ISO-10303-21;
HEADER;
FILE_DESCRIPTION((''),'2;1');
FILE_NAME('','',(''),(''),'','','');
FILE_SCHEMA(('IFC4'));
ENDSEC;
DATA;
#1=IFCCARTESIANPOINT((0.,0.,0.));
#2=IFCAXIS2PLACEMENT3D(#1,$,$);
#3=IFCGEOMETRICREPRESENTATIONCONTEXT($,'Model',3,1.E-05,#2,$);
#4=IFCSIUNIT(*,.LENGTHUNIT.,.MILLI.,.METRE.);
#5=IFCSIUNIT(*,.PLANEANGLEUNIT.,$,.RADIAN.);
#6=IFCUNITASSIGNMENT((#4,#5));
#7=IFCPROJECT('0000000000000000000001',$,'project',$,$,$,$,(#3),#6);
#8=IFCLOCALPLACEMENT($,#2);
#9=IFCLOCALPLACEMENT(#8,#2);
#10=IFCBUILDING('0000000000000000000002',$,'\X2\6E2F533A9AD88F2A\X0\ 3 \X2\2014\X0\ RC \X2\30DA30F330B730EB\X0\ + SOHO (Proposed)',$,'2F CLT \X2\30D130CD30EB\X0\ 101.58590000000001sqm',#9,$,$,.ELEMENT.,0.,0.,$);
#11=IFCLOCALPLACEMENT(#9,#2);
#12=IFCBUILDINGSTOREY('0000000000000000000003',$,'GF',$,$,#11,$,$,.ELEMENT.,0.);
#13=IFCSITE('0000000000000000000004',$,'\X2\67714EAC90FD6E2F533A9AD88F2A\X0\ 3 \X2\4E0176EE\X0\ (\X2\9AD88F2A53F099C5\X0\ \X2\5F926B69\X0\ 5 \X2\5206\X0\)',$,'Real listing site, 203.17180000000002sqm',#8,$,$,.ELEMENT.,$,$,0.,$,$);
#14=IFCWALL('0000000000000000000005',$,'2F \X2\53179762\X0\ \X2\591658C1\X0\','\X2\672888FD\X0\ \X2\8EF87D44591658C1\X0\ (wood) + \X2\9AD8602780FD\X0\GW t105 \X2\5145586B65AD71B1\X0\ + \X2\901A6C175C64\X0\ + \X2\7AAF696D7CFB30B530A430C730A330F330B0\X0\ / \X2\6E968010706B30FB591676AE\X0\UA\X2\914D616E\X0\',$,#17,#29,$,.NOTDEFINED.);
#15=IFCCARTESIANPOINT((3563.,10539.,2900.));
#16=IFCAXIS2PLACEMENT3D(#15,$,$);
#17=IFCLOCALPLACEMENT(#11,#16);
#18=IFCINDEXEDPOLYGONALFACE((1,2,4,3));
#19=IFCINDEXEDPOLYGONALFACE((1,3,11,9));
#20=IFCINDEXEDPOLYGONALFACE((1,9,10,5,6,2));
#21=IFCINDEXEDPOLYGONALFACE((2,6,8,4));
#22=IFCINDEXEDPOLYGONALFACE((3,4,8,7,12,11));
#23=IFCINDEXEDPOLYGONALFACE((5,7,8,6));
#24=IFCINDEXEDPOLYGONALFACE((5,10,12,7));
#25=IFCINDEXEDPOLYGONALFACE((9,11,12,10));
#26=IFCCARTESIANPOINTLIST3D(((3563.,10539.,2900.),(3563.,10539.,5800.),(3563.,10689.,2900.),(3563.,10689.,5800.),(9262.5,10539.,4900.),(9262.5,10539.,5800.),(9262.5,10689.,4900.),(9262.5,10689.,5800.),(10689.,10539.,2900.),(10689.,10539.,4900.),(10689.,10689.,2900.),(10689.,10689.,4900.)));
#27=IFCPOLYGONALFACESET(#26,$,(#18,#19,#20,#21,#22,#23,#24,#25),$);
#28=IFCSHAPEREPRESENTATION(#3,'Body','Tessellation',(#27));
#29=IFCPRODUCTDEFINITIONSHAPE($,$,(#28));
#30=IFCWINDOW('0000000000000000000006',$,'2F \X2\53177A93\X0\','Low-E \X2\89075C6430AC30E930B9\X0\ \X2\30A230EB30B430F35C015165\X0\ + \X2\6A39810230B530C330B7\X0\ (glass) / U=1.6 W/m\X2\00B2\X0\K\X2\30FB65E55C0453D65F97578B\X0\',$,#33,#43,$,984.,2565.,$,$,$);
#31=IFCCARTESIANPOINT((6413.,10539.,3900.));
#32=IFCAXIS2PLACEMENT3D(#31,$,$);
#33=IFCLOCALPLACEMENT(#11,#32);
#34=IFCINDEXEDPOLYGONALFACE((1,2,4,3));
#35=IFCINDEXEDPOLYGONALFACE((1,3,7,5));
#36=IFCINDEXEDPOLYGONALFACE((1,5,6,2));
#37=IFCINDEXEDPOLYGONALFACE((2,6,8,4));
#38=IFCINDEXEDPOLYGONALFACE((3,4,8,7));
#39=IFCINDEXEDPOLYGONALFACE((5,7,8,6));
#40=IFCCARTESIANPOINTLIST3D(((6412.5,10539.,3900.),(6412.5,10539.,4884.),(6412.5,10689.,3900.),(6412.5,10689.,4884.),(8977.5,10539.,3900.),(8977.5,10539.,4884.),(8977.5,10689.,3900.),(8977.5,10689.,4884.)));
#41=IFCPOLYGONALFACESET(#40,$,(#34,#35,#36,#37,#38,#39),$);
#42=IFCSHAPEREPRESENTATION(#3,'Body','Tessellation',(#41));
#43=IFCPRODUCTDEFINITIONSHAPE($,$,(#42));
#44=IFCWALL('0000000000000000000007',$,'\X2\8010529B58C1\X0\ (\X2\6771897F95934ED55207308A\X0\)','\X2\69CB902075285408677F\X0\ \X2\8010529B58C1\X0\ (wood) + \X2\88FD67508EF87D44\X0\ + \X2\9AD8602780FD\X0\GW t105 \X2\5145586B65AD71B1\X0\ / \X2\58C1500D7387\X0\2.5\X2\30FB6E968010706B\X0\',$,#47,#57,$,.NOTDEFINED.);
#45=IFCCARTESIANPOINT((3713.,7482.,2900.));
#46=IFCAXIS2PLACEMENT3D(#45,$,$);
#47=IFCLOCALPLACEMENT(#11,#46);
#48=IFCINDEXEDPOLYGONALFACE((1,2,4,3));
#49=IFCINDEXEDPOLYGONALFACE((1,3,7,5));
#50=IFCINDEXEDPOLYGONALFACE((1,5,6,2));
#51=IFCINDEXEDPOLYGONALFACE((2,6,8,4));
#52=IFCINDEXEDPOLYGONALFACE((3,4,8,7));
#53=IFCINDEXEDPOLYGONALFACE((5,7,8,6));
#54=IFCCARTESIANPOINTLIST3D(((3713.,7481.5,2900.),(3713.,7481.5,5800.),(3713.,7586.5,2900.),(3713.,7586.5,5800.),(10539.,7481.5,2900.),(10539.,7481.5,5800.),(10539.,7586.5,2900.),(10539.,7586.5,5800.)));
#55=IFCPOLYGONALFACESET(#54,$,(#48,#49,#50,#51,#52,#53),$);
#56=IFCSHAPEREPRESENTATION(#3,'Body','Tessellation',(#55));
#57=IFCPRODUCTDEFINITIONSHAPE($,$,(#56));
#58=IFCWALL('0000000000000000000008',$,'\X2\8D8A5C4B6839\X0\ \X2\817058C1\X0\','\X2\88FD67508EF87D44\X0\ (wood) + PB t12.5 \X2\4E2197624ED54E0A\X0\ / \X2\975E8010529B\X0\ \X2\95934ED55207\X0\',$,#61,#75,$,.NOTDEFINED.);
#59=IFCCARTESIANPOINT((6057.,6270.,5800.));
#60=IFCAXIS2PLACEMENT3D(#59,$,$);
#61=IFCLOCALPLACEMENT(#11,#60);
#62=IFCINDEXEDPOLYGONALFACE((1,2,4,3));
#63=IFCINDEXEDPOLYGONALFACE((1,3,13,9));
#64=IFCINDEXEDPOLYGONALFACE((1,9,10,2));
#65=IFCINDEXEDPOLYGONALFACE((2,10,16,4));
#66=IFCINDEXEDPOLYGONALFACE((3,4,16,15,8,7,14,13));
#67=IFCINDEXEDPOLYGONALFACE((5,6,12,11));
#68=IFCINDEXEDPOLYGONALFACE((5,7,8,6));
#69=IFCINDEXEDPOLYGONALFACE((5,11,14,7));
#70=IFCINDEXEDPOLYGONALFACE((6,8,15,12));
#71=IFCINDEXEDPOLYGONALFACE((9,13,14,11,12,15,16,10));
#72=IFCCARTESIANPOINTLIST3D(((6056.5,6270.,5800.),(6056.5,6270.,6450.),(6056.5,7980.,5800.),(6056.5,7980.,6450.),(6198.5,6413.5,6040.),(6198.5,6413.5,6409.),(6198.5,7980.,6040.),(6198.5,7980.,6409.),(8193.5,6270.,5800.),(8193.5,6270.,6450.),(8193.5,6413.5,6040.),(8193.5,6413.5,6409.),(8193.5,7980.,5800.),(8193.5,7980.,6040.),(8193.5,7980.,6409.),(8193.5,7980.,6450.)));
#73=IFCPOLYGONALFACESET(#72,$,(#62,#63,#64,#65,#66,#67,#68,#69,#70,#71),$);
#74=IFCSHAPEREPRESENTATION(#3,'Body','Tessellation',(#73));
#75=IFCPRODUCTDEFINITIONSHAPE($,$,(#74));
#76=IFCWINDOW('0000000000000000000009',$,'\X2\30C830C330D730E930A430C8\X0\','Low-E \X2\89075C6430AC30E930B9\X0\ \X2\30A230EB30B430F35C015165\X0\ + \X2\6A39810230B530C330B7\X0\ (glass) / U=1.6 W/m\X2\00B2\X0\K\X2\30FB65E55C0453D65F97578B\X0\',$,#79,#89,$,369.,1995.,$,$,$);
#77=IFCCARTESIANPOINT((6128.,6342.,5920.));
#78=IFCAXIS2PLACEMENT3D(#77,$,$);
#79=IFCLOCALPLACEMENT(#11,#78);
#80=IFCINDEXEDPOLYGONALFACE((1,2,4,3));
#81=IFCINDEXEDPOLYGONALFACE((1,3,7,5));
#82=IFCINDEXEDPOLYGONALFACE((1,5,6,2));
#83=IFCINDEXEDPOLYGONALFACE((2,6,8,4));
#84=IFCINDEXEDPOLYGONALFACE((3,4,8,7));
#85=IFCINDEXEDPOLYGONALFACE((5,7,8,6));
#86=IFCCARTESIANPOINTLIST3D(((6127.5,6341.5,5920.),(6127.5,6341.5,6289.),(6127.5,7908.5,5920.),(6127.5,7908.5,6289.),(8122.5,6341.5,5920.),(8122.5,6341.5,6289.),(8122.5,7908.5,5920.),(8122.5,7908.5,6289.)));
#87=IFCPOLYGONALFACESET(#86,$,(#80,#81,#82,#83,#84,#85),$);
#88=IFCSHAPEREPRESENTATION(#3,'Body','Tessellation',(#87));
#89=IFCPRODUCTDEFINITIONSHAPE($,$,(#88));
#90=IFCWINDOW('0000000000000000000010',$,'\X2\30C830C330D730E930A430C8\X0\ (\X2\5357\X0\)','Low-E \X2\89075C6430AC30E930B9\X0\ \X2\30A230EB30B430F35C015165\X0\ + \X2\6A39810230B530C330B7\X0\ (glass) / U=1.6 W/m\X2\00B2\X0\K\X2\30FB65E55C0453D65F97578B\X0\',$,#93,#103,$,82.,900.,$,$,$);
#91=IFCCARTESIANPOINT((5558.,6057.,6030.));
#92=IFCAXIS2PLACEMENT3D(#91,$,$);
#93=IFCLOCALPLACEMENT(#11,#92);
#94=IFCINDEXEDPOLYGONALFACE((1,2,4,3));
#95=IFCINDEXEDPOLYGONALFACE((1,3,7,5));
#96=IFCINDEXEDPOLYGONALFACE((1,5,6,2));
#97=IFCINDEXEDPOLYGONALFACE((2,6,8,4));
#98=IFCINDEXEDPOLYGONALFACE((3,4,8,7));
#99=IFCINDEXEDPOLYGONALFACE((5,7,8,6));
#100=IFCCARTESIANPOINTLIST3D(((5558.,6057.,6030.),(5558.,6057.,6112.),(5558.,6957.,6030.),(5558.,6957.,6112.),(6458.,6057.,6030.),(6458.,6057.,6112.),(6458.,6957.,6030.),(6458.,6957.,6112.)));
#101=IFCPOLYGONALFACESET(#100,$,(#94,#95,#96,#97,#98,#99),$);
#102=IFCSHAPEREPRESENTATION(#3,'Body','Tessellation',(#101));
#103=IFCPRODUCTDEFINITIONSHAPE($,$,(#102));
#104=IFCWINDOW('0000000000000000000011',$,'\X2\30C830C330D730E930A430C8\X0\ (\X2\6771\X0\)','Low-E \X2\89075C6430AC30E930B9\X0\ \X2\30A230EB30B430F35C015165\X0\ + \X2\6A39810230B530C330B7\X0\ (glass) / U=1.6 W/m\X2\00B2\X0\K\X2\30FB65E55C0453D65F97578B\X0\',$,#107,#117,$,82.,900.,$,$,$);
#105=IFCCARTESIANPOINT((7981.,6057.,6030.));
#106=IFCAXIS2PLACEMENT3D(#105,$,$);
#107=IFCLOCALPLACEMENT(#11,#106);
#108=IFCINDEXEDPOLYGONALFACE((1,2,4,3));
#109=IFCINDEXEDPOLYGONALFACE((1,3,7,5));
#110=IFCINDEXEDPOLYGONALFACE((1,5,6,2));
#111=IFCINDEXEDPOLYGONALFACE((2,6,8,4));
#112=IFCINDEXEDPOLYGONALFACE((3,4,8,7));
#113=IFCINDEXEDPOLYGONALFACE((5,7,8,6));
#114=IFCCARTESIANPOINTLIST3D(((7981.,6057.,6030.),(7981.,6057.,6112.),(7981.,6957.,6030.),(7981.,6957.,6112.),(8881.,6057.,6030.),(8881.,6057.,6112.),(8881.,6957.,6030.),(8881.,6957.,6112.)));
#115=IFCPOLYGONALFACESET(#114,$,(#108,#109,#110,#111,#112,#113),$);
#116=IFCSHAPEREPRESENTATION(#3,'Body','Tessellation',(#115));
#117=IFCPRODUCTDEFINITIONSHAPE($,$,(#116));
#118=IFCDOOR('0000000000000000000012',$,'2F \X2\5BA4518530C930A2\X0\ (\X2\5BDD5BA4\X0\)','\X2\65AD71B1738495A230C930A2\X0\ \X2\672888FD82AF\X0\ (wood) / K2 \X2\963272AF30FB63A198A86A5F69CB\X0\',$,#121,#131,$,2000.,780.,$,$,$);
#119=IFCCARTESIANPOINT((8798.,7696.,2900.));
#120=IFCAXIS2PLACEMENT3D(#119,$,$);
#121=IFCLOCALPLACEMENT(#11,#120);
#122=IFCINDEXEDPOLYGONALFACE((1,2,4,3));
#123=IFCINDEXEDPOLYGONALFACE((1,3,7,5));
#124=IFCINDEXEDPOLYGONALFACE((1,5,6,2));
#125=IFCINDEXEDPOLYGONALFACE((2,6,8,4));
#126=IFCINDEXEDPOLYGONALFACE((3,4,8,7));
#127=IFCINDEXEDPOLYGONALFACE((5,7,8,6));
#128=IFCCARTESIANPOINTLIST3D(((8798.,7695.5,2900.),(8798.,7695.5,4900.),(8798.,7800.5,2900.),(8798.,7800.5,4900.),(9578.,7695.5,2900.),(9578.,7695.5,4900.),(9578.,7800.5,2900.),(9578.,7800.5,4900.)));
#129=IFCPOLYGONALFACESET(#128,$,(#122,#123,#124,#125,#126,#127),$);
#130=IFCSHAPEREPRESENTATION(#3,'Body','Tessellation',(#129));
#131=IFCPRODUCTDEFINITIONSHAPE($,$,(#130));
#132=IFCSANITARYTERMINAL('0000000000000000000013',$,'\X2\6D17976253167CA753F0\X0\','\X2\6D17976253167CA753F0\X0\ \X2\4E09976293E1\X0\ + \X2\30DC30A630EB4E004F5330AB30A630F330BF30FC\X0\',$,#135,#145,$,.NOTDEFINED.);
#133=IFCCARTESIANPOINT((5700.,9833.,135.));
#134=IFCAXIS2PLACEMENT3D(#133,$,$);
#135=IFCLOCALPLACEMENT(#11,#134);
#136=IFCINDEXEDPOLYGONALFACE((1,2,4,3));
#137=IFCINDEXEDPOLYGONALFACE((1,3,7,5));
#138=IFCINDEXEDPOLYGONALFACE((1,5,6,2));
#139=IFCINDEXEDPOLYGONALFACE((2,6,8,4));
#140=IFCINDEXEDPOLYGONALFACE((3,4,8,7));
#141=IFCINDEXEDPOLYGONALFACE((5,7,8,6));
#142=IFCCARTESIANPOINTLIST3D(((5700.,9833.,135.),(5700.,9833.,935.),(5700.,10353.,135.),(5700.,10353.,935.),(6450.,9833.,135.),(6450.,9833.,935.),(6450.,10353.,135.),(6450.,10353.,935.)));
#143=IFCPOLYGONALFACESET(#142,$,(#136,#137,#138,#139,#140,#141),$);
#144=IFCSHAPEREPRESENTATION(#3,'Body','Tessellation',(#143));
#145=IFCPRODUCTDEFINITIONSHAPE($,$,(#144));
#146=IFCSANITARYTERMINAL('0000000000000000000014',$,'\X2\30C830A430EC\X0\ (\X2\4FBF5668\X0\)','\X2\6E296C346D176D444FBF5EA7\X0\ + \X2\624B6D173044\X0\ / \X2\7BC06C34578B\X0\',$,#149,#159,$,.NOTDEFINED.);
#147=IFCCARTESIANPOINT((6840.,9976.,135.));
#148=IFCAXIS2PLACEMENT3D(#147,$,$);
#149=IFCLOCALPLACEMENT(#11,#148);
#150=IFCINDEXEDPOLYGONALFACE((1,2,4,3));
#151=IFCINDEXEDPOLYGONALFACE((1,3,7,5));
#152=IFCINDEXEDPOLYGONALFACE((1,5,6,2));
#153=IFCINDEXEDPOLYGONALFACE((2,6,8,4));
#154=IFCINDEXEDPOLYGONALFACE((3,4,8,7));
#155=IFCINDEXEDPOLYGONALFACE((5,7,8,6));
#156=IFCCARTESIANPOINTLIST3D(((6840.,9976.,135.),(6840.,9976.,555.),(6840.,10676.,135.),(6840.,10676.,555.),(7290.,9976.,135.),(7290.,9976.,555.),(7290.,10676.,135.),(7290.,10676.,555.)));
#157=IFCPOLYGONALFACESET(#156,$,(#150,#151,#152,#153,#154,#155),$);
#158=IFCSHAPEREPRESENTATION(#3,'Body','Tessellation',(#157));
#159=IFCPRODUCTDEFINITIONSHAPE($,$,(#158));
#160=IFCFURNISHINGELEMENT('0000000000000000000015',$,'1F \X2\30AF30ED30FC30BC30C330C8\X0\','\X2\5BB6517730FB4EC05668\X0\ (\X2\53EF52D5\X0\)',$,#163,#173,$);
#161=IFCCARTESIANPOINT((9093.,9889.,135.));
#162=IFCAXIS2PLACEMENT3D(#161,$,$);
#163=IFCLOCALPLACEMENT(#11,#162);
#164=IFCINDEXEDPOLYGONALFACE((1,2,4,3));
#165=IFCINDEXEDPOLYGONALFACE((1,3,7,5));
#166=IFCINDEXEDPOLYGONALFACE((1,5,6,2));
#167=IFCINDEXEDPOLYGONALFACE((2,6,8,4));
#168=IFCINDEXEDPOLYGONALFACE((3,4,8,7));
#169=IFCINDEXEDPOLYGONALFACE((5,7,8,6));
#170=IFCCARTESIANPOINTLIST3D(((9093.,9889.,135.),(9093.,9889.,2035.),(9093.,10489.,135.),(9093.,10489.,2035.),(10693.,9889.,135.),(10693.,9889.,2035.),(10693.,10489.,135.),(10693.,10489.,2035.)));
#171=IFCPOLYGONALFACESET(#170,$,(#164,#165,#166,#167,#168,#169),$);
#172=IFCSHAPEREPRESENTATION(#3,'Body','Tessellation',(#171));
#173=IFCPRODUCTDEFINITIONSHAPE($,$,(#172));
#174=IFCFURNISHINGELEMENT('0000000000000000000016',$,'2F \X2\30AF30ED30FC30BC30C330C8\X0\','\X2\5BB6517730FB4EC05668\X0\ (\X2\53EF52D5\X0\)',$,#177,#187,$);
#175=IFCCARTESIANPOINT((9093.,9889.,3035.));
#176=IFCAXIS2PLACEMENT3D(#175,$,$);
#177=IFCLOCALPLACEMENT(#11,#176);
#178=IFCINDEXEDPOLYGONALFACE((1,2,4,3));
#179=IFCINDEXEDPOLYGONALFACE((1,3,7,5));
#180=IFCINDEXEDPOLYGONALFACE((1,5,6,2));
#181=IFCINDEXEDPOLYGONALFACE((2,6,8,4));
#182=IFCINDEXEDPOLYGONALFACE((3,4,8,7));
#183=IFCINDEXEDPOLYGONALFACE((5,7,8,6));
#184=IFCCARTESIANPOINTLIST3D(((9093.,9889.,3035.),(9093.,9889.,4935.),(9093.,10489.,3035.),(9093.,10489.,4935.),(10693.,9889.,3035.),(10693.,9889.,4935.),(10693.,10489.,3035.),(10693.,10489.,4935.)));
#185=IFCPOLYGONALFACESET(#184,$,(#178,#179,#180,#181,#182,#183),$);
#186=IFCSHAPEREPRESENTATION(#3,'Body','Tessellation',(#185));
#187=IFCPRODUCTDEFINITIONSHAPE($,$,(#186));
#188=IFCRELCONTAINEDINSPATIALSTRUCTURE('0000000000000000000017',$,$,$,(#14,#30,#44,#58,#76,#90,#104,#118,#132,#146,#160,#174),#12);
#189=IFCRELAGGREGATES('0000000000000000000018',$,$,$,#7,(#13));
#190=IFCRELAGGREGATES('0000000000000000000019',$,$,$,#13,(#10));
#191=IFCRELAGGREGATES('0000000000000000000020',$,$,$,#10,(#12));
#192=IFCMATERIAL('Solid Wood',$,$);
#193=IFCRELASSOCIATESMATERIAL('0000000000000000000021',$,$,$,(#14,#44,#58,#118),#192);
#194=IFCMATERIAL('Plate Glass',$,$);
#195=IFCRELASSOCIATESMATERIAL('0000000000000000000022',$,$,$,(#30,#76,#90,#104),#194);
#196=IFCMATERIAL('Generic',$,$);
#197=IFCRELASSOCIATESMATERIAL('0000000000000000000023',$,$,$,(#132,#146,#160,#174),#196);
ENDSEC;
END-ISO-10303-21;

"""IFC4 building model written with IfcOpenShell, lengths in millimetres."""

from ifc_helpers import new_model, si_unit, frame, frame_2d, origin, place, context, project, spatial, rectangle, extrude, material, element, fill, save


model = new_model("IFC4")

# Units and contexts
model_context = context("Model", 3, precision=1e-05, world=origin())
ifc_project = project(units=[si_unit("LENGTHUNIT", "METRE", prefix="MILLI"), si_unit("PLANEANGLEUNIT", "RADIAN")], contexts=[model_context])

# Site, building, storey
site_placement = place(None, origin())
site = spatial("IfcSite", under=ifc_project, at=site_placement, Name="東京都港区高輪 3 丁目 (高輪台駅 徒歩 5 分)", ObjectType="Real listing site, 203.17180000000002sqm", CompositionType="ELEMENT", RefElevation=0.0)
building_placement = place(site_placement, origin())
building = spatial("IfcBuilding", under=site, at=building_placement, Name="港区高輪 3 — RC ペンシル + SOHO (Proposed)", ObjectType="2F CLT パネル 101.58590000000001sqm", CompositionType="ELEMENT", ElevationOfRefHeight=0.0, ElevationOfTerrain=0.0)
storey_placement = place(building_placement, origin())
storey = spatial("IfcBuildingStorey", under=building, at=storey_placement, Name="GF", CompositionType="ELEMENT", Elevation=0.0)

# Wall, opening, window
ifc_material_1 = material(Name="Solid Wood")
wall_1_placement = place(storey_placement, frame((3563.0, 10539.0, 2900.0)))
wall_1 = element("IfcWall", 1, at=wall_1_placement, inside=storey, material=ifc_material_1, Name="2F 北面 外壁", Description="木製 軸組外壁 (wood) + 高性能GW t105 充填断熱 + 通気層 + 窯業系サイディング / 準耐火・外皮UA配慮", PredefinedType="NOTDEFINED", context=model_context, shape_type="SweptSolid", body=[
    extrude(rectangle(XDim=7126.0, YDim=150.0, at=frame_2d((3563.0, 75.0))), frame((3563.0, 10539.0, 2900.0)), (0.0, 0.0, 1.0), 2900.0),
])
opening_1_placement = place(storey_placement, frame((6413.0, 10539.0, 3900.0)))
opening_1 = element("IfcOpeningElement", 2, at=opening_1_placement, cuts=wall_1, PredefinedType="NOTDEFINED", context=model_context, shape_type="SweptSolid", body=[
    extrude(rectangle(XDim=2565.0, YDim=150.0, at=frame_2d((1282.0, 75.0))), frame((6413.0, 10539.0, 3900.0)), (0.0, 0.0, 1.0), 984.0),
])
ifc_material_2 = material(Name="Plate Glass")
window_1_placement = place(storey_placement, frame((6413.0, 10539.0, 3900.0)))
window_1 = element("IfcWindow", 3, at=window_1_placement, inside=storey, material=ifc_material_2, Name="2F 北窓", Description="Low-E 複層ガラス アルゴン封入 + 樹脂サッシ (glass) / U=1.6 W/m²K・日射取得型", OverallHeight=984.0, OverallWidth=2565.0, context=model_context, shape_type="SweptSolid", body=[
    extrude(rectangle(XDim=2565.0, YDim=150.0, at=frame_2d((1282.0, 75.0))), frame((6413.0, 10539.0, 3900.0)), (0.0, 0.0, 1.0), 984.0),
])
fill(opening_1, window_1)

# Wall
wall_2_placement = place(storey_placement, frame((3713.0, 7482.0, 2900.0)))
element("IfcWall", 4, at=wall_2_placement, inside=storey, material=ifc_material_1, Name="耐力壁 (東西間仕切り)", Description="構造用合板 耐力壁 (wood) + 製材軸組 + 高性能GW t105 充填断熱 / 壁倍率2.5・準耐火", PredefinedType="NOTDEFINED", context=model_context, shape_type="SweptSolid", body=[
    extrude(rectangle(XDim=6826.0, YDim=105.0, at=frame_2d((3413.0, 52.0))), frame((3713.0, 7482.0, 2900.0)), (0.0, 0.0, 1.0), 2900.0),
])

# Wall, openings, windows
wall_3_placement = place(storey_placement, frame((6057.0, 6270.0, 5800.0)))
wall_3 = element("IfcWall", 5, at=wall_3_placement, inside=storey, material=ifc_material_1, Name="越屋根 腰壁", Description="製材軸組 (wood) + PB t12.5 両面仕上 / 非耐力 間仕切", PredefinedType="NOTDEFINED", context=model_context, shape_type="SweptSolid", body=[
    extrude(rectangle(XDim=2137.0, YDim=1710.0, at=frame_2d((1068.0, 855.0))), frame((6057.0, 6270.0, 5800.0)), (0.0, 0.0, 1.0), 650.0),
])
opening_2_placement = place(storey_placement, frame((6128.0, 6342.0, 5920.0)))
opening_2 = element("IfcOpeningElement", 6, at=opening_2_placement, cuts=wall_3, PredefinedType="NOTDEFINED", context=model_context, shape_type="SweptSolid", body=[
    extrude(rectangle(XDim=1995.0, YDim=1567.0, at=frame_2d((997.0, 783.0))), frame((6128.0, 6342.0, 5920.0)), (0.0, 0.0, 1.0), 369.0),
])
opening_3_placement = place(storey_placement, frame((5558.0, 6057.0, 6030.0)))
opening_3 = element("IfcOpeningElement", 7, at=opening_3_placement, cuts=wall_3, PredefinedType="NOTDEFINED", context=model_context, shape_type="SweptSolid", body=[
    extrude(rectangle(XDim=900.0, YDim=900.0, at=frame_2d((450.0, 450.0))), frame((5558.0, 6057.0, 6030.0)), (0.0, 0.0, 1.0), 82.0),
])
opening_4_placement = place(storey_placement, frame((7981.0, 6057.0, 6030.0)))
opening_4 = element("IfcOpeningElement", 8, at=opening_4_placement, cuts=wall_3, PredefinedType="NOTDEFINED", context=model_context, shape_type="SweptSolid", body=[
    extrude(rectangle(XDim=900.0, YDim=900.0, at=frame_2d((450.0, 450.0))), frame((7981.0, 6057.0, 6030.0)), (0.0, 0.0, 1.0), 82.0),
])
window_2_placement = place(storey_placement, frame((6128.0, 6342.0, 5920.0)))
window_2 = element("IfcWindow", 9, at=window_2_placement, inside=storey, material=ifc_material_2, Name="トップライト", Description="Low-E 複層ガラス アルゴン封入 + 樹脂サッシ (glass) / U=1.6 W/m²K・日射取得型", OverallHeight=369.0, OverallWidth=1995.0, context=model_context, shape_type="SweptSolid", body=[
    extrude(rectangle(XDim=1995.0, YDim=1567.0, at=frame_2d((997.0, 783.0))), frame((6128.0, 6342.0, 5920.0)), (0.0, 0.0, 1.0), 369.0),
])
fill(opening_2, window_2)
window_3_placement = place(storey_placement, frame((5558.0, 6057.0, 6030.0)))
window_3 = element("IfcWindow", 10, at=window_3_placement, inside=storey, material=ifc_material_2, Name="トップライト (南)", Description="Low-E 複層ガラス アルゴン封入 + 樹脂サッシ (glass) / U=1.6 W/m²K・日射取得型", OverallHeight=82.0, OverallWidth=900.0, context=model_context, shape_type="SweptSolid", body=[
    extrude(rectangle(XDim=900.0, YDim=900.0, at=frame_2d((450.0, 450.0))), frame((5558.0, 6057.0, 6030.0)), (0.0, 0.0, 1.0), 82.0),
])
fill(opening_3, window_3)
window_4_placement = place(storey_placement, frame((7981.0, 6057.0, 6030.0)))
window_4 = element("IfcWindow", 11, at=window_4_placement, inside=storey, material=ifc_material_2, Name="トップライト (東)", Description="Low-E 複層ガラス アルゴン封入 + 樹脂サッシ (glass) / U=1.6 W/m²K・日射取得型", OverallHeight=82.0, OverallWidth=900.0, context=model_context, shape_type="SweptSolid", body=[
    extrude(rectangle(XDim=900.0, YDim=900.0, at=frame_2d((450.0, 450.0))), frame((7981.0, 6057.0, 6030.0)), (0.0, 0.0, 1.0), 82.0),
])
fill(opening_4, window_4)

# Door
door_placement = place(storey_placement, frame((8798.0, 7696.0, 2900.0)))
element("IfcDoor", 12, at=door_placement, inside=storey, material=ifc_material_1, Name="2F 室内ドア (寝室)", Description="断熱玄関ドア 木製芯 (wood) / K2 防犯・採風機構", OverallHeight=2000.0, OverallWidth=780.0, context=model_context, shape_type="SweptSolid", body=[
    extrude(rectangle(XDim=780.0, YDim=105.0, at=frame_2d((390.0, 52.0))), frame((8798.0, 7696.0, 2900.0)), (0.0, 0.0, 1.0), 2000.0),
])

# Sanitary terminals
ifc_material_3 = material(Name="Generic")
sanitary_terminal_1_placement = place(storey_placement, frame((5700.0, 9833.0, 135.0)))
element("IfcSanitaryTerminal", 13, at=sanitary_terminal_1_placement, inside=storey, material=ifc_material_3, Name="洗面化粧台", Description="洗面化粧台 三面鏡 + ボウル一体カウンター", PredefinedType="NOTDEFINED", context=model_context, shape_type="SweptSolid", body=[
    extrude(rectangle(XDim=750.0, YDim=520.0, at=frame_2d((375.0, 260.0))), frame((5700.0, 9833.0, 135.0)), (0.0, 0.0, 1.0), 800.0),
])
sanitary_terminal_2_placement = place(storey_placement, frame((6840.0, 9976.0, 135.0)))
element("IfcSanitaryTerminal", 14, at=sanitary_terminal_2_placement, inside=storey, material=ifc_material_3, Name="トイレ (便器)", Description="温水洗浄便座 + 手洗い / 節水型", PredefinedType="NOTDEFINED", context=model_context, shape_type="SweptSolid", body=[
    extrude(rectangle(XDim=450.0, YDim=700.0, at=frame_2d((225.0, 350.0))), frame((6840.0, 9976.0, 135.0)), (0.0, 0.0, 1.0), 420.0),
])

# Furnishing elements
furnishing_1_placement = place(storey_placement, frame((9093.0, 9889.0, 135.0)))
element("IfcFurnishingElement", 15, at=furnishing_1_placement, inside=storey, material=ifc_material_3, Name="1F クローゼット", Description="家具・什器 (可動)", context=model_context, shape_type="SweptSolid", body=[
    extrude(rectangle(XDim=1600.0, YDim=600.0, at=frame_2d((800.0, 300.0))), frame((9093.0, 9889.0, 135.0)), (0.0, 0.0, 1.0), 1900.0),
])
furnishing_2_placement = place(storey_placement, frame((9093.0, 9889.0, 3035.0)))
element("IfcFurnishingElement", 16, at=furnishing_2_placement, inside=storey, material=ifc_material_3, Name="2F クローゼット", Description="家具・什器 (可動)", context=model_context, shape_type="SweptSolid", body=[
    extrude(rectangle(XDim=1600.0, YDim=600.0, at=frame_2d((800.0, 300.0))), frame((9093.0, 9889.0, 3035.0)), (0.0, 0.0, 1.0), 1900.0),
])

save(model, "model.ifc")
